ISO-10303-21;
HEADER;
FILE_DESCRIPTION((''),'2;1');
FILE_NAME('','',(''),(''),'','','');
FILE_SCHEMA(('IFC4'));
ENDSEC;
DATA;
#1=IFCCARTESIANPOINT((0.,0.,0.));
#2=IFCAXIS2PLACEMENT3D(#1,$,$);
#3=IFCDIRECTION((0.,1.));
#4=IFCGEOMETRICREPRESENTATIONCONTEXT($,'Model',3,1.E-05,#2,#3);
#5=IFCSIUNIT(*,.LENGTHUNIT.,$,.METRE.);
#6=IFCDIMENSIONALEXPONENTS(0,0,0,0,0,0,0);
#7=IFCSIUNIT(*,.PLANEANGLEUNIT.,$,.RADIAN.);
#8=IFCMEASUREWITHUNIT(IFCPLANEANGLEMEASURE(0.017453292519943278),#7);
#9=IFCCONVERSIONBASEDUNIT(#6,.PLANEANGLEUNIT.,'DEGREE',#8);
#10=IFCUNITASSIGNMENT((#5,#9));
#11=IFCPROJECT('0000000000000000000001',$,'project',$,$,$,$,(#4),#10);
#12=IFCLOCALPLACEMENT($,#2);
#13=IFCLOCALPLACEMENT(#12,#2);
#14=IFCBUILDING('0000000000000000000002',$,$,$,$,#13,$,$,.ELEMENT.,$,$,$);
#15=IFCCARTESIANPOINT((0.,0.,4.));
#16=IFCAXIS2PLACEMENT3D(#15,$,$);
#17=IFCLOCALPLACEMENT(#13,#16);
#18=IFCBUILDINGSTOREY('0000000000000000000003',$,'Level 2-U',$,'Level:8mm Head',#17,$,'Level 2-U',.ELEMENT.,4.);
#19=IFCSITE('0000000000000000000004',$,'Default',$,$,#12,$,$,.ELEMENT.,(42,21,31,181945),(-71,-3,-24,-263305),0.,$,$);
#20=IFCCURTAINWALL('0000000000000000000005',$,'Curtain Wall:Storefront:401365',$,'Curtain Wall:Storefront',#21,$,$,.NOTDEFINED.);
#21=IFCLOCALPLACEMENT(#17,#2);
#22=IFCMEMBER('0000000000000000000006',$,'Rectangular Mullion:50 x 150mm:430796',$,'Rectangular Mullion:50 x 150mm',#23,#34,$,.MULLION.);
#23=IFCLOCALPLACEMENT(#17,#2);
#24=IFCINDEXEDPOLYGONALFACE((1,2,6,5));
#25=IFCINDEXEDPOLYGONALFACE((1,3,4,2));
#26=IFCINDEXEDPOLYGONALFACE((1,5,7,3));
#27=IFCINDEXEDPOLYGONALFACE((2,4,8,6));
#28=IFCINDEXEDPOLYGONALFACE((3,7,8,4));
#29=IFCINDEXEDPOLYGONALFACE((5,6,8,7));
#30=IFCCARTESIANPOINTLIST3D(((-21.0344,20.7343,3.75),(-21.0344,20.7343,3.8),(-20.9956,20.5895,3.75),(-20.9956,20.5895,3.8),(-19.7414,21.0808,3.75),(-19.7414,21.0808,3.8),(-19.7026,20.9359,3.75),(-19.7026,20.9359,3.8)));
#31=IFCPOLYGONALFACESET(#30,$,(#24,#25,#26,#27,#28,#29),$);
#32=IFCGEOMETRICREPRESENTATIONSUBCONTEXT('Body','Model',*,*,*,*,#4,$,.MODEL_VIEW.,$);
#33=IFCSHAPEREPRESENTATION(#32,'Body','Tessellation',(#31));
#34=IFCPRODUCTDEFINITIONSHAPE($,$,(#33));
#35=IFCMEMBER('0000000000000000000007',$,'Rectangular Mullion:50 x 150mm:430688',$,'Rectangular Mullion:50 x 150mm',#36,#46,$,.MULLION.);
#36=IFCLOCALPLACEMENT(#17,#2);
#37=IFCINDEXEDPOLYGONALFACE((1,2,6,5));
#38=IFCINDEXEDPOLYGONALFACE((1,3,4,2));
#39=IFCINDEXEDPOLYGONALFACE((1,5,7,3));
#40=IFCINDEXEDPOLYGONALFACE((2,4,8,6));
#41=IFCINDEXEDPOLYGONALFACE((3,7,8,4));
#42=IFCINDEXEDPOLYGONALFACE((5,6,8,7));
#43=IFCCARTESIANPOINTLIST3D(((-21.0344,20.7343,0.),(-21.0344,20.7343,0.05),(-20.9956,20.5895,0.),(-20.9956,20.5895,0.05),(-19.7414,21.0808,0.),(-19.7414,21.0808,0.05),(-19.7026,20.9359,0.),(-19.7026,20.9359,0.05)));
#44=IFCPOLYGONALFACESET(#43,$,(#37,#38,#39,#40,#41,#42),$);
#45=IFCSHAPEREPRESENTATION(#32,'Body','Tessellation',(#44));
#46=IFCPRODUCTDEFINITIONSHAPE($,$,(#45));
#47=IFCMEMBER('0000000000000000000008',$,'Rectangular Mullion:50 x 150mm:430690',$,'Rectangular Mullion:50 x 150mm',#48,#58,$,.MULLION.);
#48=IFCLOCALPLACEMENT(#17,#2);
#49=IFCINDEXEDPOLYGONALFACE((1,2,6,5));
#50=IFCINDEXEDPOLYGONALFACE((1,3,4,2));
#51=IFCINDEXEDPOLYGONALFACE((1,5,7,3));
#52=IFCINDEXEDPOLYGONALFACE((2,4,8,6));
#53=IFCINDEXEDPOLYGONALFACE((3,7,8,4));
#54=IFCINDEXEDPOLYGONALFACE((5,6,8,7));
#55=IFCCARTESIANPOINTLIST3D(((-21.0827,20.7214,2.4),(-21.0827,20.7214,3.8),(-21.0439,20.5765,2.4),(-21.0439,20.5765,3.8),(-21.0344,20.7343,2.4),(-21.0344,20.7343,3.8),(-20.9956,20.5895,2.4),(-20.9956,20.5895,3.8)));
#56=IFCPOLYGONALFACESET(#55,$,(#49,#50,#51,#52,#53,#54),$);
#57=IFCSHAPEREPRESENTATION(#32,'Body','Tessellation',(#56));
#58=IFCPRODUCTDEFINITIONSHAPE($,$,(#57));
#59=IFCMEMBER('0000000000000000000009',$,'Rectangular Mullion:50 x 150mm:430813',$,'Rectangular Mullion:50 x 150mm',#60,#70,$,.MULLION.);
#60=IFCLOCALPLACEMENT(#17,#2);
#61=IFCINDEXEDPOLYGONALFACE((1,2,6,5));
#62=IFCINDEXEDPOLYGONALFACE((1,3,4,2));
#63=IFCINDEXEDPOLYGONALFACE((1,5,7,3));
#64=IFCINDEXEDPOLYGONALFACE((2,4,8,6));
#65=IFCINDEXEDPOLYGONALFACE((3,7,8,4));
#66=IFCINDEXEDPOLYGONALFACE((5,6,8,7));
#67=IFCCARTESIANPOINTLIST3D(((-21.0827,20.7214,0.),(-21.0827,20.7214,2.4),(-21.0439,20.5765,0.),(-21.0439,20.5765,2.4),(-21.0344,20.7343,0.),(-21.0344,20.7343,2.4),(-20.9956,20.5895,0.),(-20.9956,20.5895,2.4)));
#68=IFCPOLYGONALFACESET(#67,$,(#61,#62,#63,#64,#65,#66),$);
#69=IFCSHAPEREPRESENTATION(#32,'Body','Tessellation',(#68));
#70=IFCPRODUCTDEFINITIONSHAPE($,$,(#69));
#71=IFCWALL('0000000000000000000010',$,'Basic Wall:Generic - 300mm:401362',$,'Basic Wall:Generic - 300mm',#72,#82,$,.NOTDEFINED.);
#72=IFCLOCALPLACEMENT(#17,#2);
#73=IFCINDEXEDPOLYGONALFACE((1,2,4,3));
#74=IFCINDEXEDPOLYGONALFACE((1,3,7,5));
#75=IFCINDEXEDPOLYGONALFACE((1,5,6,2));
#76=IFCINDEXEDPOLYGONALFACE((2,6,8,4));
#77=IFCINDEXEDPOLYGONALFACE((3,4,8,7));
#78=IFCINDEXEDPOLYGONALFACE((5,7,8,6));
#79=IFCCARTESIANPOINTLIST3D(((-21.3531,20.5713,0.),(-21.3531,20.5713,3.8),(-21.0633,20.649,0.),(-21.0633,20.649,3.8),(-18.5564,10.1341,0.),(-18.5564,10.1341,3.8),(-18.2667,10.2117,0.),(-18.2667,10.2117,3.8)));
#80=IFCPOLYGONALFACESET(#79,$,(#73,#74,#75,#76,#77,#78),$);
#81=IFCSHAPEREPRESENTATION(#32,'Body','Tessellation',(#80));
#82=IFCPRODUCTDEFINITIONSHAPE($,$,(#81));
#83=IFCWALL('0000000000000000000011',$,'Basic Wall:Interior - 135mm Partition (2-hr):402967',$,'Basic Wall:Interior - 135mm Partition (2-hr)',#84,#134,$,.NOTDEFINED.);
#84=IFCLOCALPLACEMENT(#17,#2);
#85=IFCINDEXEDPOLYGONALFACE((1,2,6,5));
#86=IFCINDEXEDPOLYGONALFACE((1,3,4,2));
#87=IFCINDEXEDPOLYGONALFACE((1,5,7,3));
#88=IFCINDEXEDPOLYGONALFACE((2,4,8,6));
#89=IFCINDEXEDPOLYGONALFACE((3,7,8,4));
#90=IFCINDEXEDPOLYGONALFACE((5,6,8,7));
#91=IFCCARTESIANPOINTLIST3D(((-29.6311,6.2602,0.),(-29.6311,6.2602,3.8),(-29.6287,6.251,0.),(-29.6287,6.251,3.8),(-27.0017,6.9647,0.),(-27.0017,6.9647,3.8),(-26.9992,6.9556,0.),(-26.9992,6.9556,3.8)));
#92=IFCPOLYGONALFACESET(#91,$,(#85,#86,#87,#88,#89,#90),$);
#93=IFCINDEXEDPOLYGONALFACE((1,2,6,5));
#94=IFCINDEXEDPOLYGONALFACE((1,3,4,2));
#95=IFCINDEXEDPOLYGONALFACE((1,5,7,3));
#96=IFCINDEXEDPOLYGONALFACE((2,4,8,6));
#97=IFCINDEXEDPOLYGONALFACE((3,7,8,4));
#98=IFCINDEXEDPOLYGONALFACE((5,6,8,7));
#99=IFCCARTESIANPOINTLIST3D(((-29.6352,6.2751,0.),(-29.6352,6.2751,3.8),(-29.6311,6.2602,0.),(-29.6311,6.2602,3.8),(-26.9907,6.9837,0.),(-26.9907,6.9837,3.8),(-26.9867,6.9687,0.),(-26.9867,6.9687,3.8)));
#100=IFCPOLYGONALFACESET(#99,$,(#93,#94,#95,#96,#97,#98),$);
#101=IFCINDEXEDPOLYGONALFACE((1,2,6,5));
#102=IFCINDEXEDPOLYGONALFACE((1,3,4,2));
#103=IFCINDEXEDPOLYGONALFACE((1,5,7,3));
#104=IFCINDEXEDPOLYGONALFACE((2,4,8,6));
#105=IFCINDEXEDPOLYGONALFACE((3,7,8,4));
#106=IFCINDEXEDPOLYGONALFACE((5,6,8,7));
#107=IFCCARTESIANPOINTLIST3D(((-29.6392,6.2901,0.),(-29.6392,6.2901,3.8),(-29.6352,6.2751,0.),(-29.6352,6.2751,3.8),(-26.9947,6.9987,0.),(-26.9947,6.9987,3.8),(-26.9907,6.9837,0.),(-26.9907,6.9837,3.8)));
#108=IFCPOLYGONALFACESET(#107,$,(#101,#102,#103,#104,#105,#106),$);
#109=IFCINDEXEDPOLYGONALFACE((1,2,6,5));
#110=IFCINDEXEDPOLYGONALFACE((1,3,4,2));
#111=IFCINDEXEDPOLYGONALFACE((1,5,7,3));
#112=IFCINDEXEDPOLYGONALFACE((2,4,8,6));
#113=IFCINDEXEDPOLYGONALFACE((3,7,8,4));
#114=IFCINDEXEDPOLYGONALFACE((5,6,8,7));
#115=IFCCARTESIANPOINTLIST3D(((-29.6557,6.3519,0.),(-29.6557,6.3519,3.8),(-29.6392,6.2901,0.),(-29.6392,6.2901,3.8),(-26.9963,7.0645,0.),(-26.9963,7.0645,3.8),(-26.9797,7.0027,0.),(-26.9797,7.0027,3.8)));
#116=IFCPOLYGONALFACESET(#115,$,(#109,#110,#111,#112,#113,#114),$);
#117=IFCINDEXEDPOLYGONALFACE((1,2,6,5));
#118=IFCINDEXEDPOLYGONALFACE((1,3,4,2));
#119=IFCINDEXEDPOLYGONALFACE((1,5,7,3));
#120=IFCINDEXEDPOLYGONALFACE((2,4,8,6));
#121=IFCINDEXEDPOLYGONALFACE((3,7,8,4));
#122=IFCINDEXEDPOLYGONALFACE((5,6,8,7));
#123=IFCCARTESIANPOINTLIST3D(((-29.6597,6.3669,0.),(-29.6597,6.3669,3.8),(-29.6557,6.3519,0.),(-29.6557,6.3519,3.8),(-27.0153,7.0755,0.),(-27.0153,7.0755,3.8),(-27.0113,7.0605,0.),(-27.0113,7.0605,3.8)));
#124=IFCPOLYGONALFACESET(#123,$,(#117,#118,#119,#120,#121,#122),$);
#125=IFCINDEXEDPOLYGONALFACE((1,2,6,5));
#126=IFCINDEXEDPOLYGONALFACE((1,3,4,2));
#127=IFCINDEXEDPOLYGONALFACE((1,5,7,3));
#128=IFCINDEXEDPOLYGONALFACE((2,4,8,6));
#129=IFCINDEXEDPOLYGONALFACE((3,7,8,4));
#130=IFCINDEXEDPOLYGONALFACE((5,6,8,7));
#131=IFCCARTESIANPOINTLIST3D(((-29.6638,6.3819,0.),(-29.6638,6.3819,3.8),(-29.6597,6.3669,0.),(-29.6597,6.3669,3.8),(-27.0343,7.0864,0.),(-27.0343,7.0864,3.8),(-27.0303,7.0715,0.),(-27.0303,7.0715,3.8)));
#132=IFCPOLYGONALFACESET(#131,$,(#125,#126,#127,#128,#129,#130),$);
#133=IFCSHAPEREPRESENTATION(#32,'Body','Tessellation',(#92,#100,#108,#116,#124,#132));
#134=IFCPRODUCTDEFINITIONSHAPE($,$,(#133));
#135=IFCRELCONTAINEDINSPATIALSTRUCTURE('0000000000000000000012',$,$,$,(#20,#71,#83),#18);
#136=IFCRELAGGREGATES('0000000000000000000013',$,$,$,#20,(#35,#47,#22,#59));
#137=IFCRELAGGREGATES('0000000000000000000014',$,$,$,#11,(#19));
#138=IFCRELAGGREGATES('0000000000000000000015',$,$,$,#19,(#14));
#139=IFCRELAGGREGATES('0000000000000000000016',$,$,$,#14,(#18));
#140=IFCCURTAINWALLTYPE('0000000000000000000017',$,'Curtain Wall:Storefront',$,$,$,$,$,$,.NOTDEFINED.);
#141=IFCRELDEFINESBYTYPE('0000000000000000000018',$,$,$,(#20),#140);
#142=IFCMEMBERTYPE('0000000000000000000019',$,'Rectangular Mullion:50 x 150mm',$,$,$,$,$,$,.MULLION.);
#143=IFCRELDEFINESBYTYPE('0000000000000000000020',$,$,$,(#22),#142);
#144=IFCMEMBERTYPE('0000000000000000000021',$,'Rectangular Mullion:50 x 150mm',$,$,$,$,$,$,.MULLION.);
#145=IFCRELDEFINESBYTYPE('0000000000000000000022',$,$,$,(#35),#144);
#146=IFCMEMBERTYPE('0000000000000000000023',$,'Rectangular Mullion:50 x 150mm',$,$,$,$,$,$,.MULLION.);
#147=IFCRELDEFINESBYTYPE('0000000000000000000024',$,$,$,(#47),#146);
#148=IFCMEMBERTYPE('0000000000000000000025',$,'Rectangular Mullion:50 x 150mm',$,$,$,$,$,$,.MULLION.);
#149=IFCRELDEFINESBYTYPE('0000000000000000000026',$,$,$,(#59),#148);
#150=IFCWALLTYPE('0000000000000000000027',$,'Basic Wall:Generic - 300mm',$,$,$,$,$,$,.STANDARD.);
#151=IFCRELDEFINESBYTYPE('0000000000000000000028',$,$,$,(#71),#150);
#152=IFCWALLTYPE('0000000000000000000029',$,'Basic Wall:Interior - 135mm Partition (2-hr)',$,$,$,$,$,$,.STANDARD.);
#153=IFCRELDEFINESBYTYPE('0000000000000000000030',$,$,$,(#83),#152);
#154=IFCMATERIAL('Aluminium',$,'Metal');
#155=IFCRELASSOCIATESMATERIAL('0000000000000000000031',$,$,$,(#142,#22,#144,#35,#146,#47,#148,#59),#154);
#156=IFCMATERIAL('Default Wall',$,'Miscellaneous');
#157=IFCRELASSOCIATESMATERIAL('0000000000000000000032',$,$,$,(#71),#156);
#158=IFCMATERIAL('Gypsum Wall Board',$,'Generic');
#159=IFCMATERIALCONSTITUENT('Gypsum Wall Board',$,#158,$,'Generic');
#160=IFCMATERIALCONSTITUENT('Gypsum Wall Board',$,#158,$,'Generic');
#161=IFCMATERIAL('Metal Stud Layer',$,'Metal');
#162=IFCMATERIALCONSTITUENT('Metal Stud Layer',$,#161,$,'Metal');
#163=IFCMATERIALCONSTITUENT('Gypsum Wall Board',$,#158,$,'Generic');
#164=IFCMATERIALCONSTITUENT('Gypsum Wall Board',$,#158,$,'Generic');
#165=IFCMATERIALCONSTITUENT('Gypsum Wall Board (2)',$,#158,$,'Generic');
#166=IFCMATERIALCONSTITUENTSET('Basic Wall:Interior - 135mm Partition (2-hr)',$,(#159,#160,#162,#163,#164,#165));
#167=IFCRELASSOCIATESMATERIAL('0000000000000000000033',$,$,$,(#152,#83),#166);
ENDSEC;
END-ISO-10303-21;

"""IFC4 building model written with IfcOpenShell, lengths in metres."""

from ifc_helpers import new_model, entity, si_unit, converted_unit, direction, frame, origin, place, context, subcontext, project, spatial, indexed_curve, outline, extrude, source, transform, mapped, material, constituent, constituent_set, type_object, type_shapes, element, aggregate, save


model = new_model("IFC4")

# Units and contexts
model_context = context("Model", 3, precision=1e-05, world=origin(), true_north=direction((0.0, 1.0)))
body_context = subcontext(model_context, "Body", "Model", "MODEL_VIEW")
ifc_project = project(units=[si_unit("LENGTHUNIT", "METRE"), converted_unit("PLANEANGLEUNIT", "DEGREE", entity("IfcPlaneAngleMeasure", 0.017453292519943278), si_unit("PLANEANGLEUNIT", "RADIAN"), dimensions=[0, 0, 0, 0, 0, 0, 0])], contexts=[model_context])

# Site, building, storey
site_placement = place(None, origin())
site = spatial("IfcSite", under=ifc_project, at=site_placement, Name="Default", CompositionType="ELEMENT", RefLatitude=(42, 21, 31, 181945), RefLongitude=(-71, -3, -24, -263305), RefElevation=0.0)
building_placement = place(site_placement, origin())
building = spatial("IfcBuilding", under=site, at=building_placement, CompositionType="ELEMENT")
storey_placement = place(building_placement, frame((0.0, 0.0, 4.0)))
storey = spatial("IfcBuildingStorey", under=building, at=storey_placement, Name="Level 2-U", ObjectType="Level:8mm Head", LongName="Level 2-U", CompositionType="ELEMENT", Elevation=4.0)

# Curtain wall, members
curtain_wall_type = type_object("IfcCurtainWallType", Name="Curtain Wall:Storefront", PredefinedType="NOTDEFINED")
curtain_wall_placement = place(storey_placement, frame((0.0, 0.0, -4.0)))
curtain_wall = element("IfcCurtainWall", 1, at=curtain_wall_placement, inside=storey, type_object=curtain_wall_type, Name="Curtain Wall:Storefront:401365", ObjectType="Curtain Wall:Storefront", PredefinedType="NOTDEFINED")
ifc_material_1 = material(Name="Aluminium", Category="Metal")
member_type_1 = type_object("IfcMemberType", Name="Rectangular Mullion:50 x 150mm", PredefinedType="MULLION", material=ifc_material_1)
shared_shape_1 = source(origin(), body_context, "Body", "SweptSolid", [
    extrude(outline(indexed_curve([(-0.025, -0.075), (0.025, -0.075), (0.025, 0.075), (-0.025, 0.075), (-0.025, -0.075)], self_intersect=False)), frame((-0.025, 0.0, -1.3386), z_axis=(0.0, 0.0, 1.0), x_axis=(-1.0, 0.0, 0.0)), (0.0, 0.0, 1.0), 1.3386),
])
type_shapes(member_type_1, [shared_shape_1])
member_1_placement = place(curtain_wall_placement, frame((-19.722, 21.0084, 7.8), z_axis=(0.965926, 0.258819, 0.0), x_axis=(0.0, 0.0, 1.0)))
member_1 = element("IfcMember", 2, at=member_1_placement, type_object=member_type_1, material=ifc_material_1, Name="Rectangular Mullion:50 x 150mm:430796", ObjectType="Rectangular Mullion:50 x 150mm", PredefinedType="MULLION", context=body_context, shape_type="MappedRepresentation", body=[
    mapped(shared_shape_1, transform((0.0, 0.0, 0.0), scale=1.0)),
])
member_type_2 = type_object("IfcMemberType", Name="Rectangular Mullion:50 x 150mm", PredefinedType="MULLION", material=ifc_material_1)
shared_shape_2 = source(origin(), body_context, "Body", "SweptSolid", [
    extrude(outline(indexed_curve([(-0.025, -0.075), (0.025, -0.075), (0.025, 0.075), (-0.025, 0.075), (-0.025, -0.075)], self_intersect=False)), frame((-0.025, 0.0, -1.3386), z_axis=(0.0, 0.0, 1.0), x_axis=(-1.0, 0.0, 0.0)), (0.0, 0.0, 1.0), 1.3386),
])
type_shapes(member_type_2, [shared_shape_2])
member_2_placement = place(curtain_wall_placement, frame((-21.015, 20.6619, 4.0), z_axis=(-0.965926, -0.258819, 0.0), x_axis=(0.0, 0.0, -1.0)))
member_2 = element("IfcMember", 3, at=member_2_placement, type_object=member_type_2, material=ifc_material_1, Name="Rectangular Mullion:50 x 150mm:430688", ObjectType="Rectangular Mullion:50 x 150mm", PredefinedType="MULLION", context=body_context, shape_type="MappedRepresentation", body=[
    mapped(shared_shape_2, transform((0.0, 0.0, 0.0), scale=1.0)),
])
member_type_3 = type_object("IfcMemberType", Name="Rectangular Mullion:50 x 150mm", PredefinedType="MULLION", material=ifc_material_1)
shared_shape_3 = source(origin(), body_context, "Body", "SweptSolid", [
    extrude(outline(indexed_curve([(-0.025, -0.075), (0.025, -0.075), (0.025, 0.075), (-0.025, 0.075), (-0.025, -0.075)], self_intersect=False)), frame((-0.025, 0.0, -1.4), z_axis=(0.0, 0.0, 1.0), x_axis=(-1.0, 0.0, 0.0)), (0.0, 0.0, 1.0), 1.4),
])
type_shapes(member_type_3, [shared_shape_3])
member_3_placement = place(curtain_wall_placement, frame((-21.0633, 20.649, 7.8), z_axis=(0.0, 0.0, 1.0), x_axis=(-0.965926, -0.258819, 0.0)))
member_3 = element("IfcMember", 4, at=member_3_placement, type_object=member_type_3, material=ifc_material_1, Name="Rectangular Mullion:50 x 150mm:430690", ObjectType="Rectangular Mullion:50 x 150mm", PredefinedType="MULLION", context=body_context, shape_type="MappedRepresentation", body=[
    mapped(shared_shape_3, transform((0.0, 0.0, 0.0), scale=1.0)),
])
member_type_4 = type_object("IfcMemberType", Name="Rectangular Mullion:50 x 150mm", PredefinedType="MULLION", material=ifc_material_1)
shared_shape_4 = source(origin(), body_context, "Body", "SweptSolid", [
    extrude(outline(indexed_curve([(-0.025, -0.075), (0.025, -0.075), (0.025, 0.075), (-0.025, 0.075), (-0.025, -0.075)], self_intersect=False)), frame((-0.025, 0.0, -2.4), z_axis=(0.0, 0.0, 1.0), x_axis=(-1.0, 0.0, 0.0)), (0.0, 0.0, 1.0), 2.4),
])
type_shapes(member_type_4, [shared_shape_4])
member_4_placement = place(curtain_wall_placement, frame((-21.0633, 20.649, 6.4), z_axis=(0.0, 0.0, 1.0), x_axis=(-0.965926, -0.258819, 0.0)))
member_4 = element("IfcMember", 5, at=member_4_placement, type_object=member_type_4, material=ifc_material_1, Name="Rectangular Mullion:50 x 150mm:430813", ObjectType="Rectangular Mullion:50 x 150mm", PredefinedType="MULLION", context=body_context, shape_type="MappedRepresentation", body=[
    mapped(shared_shape_4, transform((0.0, 0.0, 0.0), scale=1.0)),
])
aggregate(curtain_wall, [member_2, member_3, member_1, member_4])

# Wall
ifc_material_2 = material(Name="Default Wall", Category="Miscellaneous")
wall_type_1 = type_object("IfcWallType", Name="Basic Wall:Generic - 300mm", PredefinedType="STANDARD")
wall_1_placement = place(storey_placement, frame((-18.4115, 10.1729, 0.0), z_axis=(0.0, 0.0, 1.0), x_axis=(-0.258819, 0.965926, 0.0)))
element("IfcWall", 6, at=wall_1_placement, inside=storey, type_object=wall_type_1, material=ifc_material_2, Name="Basic Wall:Generic - 300mm:401362", ObjectType="Basic Wall:Generic - 300mm", PredefinedType="NOTDEFINED", context=body_context, shape_type="SweptSolid", body=[
    extrude(outline(indexed_curve([(10.8054, 0.15), (0.0, 0.15), (0.0, -0.15), (10.8054, -0.15), (10.8054, 0.15)], self_intersect=False)), origin(), (0.0, 0.0, 1.0), 3.8),
])

# Shared definitions
ifc_material_3 = material(Name="Gypsum Wall Board", Category="Generic")
ifc_constituent_1 = constituent(ifc_material_3, Name="Gypsum Wall Board", Category="Generic")
ifc_constituent_2 = constituent(ifc_material_3, Name="Gypsum Wall Board", Category="Generic")
ifc_material_4 = material(Name="Metal Stud Layer", Category="Metal")
ifc_constituent_3 = constituent(ifc_material_4, Name="Metal Stud Layer", Category="Metal")
ifc_constituent_4 = constituent(ifc_material_3, Name="Gypsum Wall Board", Category="Generic")
ifc_constituent_5 = constituent(ifc_material_3, Name="Gypsum Wall Board", Category="Generic")
ifc_constituent_6 = constituent(ifc_material_3, Name="Gypsum Wall Board (2)", Category="Generic")
ifc_constituent_set_1 = constituent_set(constituents=[ifc_constituent_1, ifc_constituent_2, ifc_constituent_3, ifc_constituent_4, ifc_constituent_5, ifc_constituent_6], Name="Basic Wall:Interior - 135mm Partition (2-hr)")
wall_type_2 = type_object("IfcWallType", Name="Basic Wall:Interior - 135mm Partition (2-hr)", PredefinedType="STANDARD", material=ifc_constituent_set_1)

# Wall
wall_2_placement = place(storey_placement, frame((-29.6462, 6.3164, 0.0), z_axis=(0.0, 0.0, 1.0), x_axis=(0.965926, 0.258819, 0.0)))
element("IfcWall", 7, at=wall_2_placement, inside=storey, type_object=wall_type_2, material=ifc_constituent_set_1, Name="Basic Wall:Interior - 135mm Partition (2-hr):402967", ObjectType="Basic Wall:Interior - 135mm Partition (2-hr)", PredefinedType="NOTDEFINED", context=body_context, shape_type="SweptSolid", body=[
    extrude(outline(indexed_curve([(-0.0047, -1.3611), (0.0048, -1.3611), (0.0047, 1.3611), (-0.0048, 1.3611), (-0.0047, -1.3611)], self_intersect=False)), frame((1.3611, -0.063, 0.0), z_axis=(0.0, 0.0, 1.0), x_axis=(0.0, 1.0, 0.0)), (0.0, 0.0, 1.0), 3.8),
    extrude(outline(indexed_curve([(-1.3689, -0.0077), (1.3689, -0.0078), (1.3689, 0.0077), (-1.3689, 0.0078), (-1.3689, -0.0077)], self_intersect=False)), frame((1.3689, -0.0505, 0.0)), (0.0, 0.0, 1.0), 3.8),
    extrude(outline(indexed_curve([(-1.3689, -0.0077), (1.3689, -0.0078), (1.3689, 0.0077), (-1.3689, 0.0078), (-1.3689, -0.0077)], self_intersect=False)), frame((1.3689, -0.035, 0.0)), (0.0, 0.0, 1.0), 3.8),
    extrude(outline(indexed_curve([(-1.3766, -0.032), (1.3766, -0.032), (1.3766, 0.032), (-1.3766, 0.032), (-1.3766, -0.032)], self_intersect=False)), frame((1.3766, 0.0048, 0.0)), (0.0, 0.0, 1.0), 3.8),
    extrude(outline(indexed_curve([(-1.3689, -0.0077), (1.3689, -0.0078), (1.3689, 0.0077), (-1.3689, 0.0078), (-1.3689, -0.0077)], self_intersect=False)), frame((1.3689, 0.0445, 0.0)), (0.0, 0.0, 1.0), 3.8),
    extrude(outline(indexed_curve([(-0.0078, -1.3611), (0.0077, -1.3611), (0.0078, 1.3611), (-0.0077, 1.3611), (-0.0078, -1.3611)], self_intersect=False)), frame((1.3611, 0.06, 0.0), z_axis=(0.0, 0.0, 1.0), x_axis=(0.0, -1.0, 0.0)), (0.0, 0.0, 1.0), 3.8),
])

save(model, "model.ifc")
